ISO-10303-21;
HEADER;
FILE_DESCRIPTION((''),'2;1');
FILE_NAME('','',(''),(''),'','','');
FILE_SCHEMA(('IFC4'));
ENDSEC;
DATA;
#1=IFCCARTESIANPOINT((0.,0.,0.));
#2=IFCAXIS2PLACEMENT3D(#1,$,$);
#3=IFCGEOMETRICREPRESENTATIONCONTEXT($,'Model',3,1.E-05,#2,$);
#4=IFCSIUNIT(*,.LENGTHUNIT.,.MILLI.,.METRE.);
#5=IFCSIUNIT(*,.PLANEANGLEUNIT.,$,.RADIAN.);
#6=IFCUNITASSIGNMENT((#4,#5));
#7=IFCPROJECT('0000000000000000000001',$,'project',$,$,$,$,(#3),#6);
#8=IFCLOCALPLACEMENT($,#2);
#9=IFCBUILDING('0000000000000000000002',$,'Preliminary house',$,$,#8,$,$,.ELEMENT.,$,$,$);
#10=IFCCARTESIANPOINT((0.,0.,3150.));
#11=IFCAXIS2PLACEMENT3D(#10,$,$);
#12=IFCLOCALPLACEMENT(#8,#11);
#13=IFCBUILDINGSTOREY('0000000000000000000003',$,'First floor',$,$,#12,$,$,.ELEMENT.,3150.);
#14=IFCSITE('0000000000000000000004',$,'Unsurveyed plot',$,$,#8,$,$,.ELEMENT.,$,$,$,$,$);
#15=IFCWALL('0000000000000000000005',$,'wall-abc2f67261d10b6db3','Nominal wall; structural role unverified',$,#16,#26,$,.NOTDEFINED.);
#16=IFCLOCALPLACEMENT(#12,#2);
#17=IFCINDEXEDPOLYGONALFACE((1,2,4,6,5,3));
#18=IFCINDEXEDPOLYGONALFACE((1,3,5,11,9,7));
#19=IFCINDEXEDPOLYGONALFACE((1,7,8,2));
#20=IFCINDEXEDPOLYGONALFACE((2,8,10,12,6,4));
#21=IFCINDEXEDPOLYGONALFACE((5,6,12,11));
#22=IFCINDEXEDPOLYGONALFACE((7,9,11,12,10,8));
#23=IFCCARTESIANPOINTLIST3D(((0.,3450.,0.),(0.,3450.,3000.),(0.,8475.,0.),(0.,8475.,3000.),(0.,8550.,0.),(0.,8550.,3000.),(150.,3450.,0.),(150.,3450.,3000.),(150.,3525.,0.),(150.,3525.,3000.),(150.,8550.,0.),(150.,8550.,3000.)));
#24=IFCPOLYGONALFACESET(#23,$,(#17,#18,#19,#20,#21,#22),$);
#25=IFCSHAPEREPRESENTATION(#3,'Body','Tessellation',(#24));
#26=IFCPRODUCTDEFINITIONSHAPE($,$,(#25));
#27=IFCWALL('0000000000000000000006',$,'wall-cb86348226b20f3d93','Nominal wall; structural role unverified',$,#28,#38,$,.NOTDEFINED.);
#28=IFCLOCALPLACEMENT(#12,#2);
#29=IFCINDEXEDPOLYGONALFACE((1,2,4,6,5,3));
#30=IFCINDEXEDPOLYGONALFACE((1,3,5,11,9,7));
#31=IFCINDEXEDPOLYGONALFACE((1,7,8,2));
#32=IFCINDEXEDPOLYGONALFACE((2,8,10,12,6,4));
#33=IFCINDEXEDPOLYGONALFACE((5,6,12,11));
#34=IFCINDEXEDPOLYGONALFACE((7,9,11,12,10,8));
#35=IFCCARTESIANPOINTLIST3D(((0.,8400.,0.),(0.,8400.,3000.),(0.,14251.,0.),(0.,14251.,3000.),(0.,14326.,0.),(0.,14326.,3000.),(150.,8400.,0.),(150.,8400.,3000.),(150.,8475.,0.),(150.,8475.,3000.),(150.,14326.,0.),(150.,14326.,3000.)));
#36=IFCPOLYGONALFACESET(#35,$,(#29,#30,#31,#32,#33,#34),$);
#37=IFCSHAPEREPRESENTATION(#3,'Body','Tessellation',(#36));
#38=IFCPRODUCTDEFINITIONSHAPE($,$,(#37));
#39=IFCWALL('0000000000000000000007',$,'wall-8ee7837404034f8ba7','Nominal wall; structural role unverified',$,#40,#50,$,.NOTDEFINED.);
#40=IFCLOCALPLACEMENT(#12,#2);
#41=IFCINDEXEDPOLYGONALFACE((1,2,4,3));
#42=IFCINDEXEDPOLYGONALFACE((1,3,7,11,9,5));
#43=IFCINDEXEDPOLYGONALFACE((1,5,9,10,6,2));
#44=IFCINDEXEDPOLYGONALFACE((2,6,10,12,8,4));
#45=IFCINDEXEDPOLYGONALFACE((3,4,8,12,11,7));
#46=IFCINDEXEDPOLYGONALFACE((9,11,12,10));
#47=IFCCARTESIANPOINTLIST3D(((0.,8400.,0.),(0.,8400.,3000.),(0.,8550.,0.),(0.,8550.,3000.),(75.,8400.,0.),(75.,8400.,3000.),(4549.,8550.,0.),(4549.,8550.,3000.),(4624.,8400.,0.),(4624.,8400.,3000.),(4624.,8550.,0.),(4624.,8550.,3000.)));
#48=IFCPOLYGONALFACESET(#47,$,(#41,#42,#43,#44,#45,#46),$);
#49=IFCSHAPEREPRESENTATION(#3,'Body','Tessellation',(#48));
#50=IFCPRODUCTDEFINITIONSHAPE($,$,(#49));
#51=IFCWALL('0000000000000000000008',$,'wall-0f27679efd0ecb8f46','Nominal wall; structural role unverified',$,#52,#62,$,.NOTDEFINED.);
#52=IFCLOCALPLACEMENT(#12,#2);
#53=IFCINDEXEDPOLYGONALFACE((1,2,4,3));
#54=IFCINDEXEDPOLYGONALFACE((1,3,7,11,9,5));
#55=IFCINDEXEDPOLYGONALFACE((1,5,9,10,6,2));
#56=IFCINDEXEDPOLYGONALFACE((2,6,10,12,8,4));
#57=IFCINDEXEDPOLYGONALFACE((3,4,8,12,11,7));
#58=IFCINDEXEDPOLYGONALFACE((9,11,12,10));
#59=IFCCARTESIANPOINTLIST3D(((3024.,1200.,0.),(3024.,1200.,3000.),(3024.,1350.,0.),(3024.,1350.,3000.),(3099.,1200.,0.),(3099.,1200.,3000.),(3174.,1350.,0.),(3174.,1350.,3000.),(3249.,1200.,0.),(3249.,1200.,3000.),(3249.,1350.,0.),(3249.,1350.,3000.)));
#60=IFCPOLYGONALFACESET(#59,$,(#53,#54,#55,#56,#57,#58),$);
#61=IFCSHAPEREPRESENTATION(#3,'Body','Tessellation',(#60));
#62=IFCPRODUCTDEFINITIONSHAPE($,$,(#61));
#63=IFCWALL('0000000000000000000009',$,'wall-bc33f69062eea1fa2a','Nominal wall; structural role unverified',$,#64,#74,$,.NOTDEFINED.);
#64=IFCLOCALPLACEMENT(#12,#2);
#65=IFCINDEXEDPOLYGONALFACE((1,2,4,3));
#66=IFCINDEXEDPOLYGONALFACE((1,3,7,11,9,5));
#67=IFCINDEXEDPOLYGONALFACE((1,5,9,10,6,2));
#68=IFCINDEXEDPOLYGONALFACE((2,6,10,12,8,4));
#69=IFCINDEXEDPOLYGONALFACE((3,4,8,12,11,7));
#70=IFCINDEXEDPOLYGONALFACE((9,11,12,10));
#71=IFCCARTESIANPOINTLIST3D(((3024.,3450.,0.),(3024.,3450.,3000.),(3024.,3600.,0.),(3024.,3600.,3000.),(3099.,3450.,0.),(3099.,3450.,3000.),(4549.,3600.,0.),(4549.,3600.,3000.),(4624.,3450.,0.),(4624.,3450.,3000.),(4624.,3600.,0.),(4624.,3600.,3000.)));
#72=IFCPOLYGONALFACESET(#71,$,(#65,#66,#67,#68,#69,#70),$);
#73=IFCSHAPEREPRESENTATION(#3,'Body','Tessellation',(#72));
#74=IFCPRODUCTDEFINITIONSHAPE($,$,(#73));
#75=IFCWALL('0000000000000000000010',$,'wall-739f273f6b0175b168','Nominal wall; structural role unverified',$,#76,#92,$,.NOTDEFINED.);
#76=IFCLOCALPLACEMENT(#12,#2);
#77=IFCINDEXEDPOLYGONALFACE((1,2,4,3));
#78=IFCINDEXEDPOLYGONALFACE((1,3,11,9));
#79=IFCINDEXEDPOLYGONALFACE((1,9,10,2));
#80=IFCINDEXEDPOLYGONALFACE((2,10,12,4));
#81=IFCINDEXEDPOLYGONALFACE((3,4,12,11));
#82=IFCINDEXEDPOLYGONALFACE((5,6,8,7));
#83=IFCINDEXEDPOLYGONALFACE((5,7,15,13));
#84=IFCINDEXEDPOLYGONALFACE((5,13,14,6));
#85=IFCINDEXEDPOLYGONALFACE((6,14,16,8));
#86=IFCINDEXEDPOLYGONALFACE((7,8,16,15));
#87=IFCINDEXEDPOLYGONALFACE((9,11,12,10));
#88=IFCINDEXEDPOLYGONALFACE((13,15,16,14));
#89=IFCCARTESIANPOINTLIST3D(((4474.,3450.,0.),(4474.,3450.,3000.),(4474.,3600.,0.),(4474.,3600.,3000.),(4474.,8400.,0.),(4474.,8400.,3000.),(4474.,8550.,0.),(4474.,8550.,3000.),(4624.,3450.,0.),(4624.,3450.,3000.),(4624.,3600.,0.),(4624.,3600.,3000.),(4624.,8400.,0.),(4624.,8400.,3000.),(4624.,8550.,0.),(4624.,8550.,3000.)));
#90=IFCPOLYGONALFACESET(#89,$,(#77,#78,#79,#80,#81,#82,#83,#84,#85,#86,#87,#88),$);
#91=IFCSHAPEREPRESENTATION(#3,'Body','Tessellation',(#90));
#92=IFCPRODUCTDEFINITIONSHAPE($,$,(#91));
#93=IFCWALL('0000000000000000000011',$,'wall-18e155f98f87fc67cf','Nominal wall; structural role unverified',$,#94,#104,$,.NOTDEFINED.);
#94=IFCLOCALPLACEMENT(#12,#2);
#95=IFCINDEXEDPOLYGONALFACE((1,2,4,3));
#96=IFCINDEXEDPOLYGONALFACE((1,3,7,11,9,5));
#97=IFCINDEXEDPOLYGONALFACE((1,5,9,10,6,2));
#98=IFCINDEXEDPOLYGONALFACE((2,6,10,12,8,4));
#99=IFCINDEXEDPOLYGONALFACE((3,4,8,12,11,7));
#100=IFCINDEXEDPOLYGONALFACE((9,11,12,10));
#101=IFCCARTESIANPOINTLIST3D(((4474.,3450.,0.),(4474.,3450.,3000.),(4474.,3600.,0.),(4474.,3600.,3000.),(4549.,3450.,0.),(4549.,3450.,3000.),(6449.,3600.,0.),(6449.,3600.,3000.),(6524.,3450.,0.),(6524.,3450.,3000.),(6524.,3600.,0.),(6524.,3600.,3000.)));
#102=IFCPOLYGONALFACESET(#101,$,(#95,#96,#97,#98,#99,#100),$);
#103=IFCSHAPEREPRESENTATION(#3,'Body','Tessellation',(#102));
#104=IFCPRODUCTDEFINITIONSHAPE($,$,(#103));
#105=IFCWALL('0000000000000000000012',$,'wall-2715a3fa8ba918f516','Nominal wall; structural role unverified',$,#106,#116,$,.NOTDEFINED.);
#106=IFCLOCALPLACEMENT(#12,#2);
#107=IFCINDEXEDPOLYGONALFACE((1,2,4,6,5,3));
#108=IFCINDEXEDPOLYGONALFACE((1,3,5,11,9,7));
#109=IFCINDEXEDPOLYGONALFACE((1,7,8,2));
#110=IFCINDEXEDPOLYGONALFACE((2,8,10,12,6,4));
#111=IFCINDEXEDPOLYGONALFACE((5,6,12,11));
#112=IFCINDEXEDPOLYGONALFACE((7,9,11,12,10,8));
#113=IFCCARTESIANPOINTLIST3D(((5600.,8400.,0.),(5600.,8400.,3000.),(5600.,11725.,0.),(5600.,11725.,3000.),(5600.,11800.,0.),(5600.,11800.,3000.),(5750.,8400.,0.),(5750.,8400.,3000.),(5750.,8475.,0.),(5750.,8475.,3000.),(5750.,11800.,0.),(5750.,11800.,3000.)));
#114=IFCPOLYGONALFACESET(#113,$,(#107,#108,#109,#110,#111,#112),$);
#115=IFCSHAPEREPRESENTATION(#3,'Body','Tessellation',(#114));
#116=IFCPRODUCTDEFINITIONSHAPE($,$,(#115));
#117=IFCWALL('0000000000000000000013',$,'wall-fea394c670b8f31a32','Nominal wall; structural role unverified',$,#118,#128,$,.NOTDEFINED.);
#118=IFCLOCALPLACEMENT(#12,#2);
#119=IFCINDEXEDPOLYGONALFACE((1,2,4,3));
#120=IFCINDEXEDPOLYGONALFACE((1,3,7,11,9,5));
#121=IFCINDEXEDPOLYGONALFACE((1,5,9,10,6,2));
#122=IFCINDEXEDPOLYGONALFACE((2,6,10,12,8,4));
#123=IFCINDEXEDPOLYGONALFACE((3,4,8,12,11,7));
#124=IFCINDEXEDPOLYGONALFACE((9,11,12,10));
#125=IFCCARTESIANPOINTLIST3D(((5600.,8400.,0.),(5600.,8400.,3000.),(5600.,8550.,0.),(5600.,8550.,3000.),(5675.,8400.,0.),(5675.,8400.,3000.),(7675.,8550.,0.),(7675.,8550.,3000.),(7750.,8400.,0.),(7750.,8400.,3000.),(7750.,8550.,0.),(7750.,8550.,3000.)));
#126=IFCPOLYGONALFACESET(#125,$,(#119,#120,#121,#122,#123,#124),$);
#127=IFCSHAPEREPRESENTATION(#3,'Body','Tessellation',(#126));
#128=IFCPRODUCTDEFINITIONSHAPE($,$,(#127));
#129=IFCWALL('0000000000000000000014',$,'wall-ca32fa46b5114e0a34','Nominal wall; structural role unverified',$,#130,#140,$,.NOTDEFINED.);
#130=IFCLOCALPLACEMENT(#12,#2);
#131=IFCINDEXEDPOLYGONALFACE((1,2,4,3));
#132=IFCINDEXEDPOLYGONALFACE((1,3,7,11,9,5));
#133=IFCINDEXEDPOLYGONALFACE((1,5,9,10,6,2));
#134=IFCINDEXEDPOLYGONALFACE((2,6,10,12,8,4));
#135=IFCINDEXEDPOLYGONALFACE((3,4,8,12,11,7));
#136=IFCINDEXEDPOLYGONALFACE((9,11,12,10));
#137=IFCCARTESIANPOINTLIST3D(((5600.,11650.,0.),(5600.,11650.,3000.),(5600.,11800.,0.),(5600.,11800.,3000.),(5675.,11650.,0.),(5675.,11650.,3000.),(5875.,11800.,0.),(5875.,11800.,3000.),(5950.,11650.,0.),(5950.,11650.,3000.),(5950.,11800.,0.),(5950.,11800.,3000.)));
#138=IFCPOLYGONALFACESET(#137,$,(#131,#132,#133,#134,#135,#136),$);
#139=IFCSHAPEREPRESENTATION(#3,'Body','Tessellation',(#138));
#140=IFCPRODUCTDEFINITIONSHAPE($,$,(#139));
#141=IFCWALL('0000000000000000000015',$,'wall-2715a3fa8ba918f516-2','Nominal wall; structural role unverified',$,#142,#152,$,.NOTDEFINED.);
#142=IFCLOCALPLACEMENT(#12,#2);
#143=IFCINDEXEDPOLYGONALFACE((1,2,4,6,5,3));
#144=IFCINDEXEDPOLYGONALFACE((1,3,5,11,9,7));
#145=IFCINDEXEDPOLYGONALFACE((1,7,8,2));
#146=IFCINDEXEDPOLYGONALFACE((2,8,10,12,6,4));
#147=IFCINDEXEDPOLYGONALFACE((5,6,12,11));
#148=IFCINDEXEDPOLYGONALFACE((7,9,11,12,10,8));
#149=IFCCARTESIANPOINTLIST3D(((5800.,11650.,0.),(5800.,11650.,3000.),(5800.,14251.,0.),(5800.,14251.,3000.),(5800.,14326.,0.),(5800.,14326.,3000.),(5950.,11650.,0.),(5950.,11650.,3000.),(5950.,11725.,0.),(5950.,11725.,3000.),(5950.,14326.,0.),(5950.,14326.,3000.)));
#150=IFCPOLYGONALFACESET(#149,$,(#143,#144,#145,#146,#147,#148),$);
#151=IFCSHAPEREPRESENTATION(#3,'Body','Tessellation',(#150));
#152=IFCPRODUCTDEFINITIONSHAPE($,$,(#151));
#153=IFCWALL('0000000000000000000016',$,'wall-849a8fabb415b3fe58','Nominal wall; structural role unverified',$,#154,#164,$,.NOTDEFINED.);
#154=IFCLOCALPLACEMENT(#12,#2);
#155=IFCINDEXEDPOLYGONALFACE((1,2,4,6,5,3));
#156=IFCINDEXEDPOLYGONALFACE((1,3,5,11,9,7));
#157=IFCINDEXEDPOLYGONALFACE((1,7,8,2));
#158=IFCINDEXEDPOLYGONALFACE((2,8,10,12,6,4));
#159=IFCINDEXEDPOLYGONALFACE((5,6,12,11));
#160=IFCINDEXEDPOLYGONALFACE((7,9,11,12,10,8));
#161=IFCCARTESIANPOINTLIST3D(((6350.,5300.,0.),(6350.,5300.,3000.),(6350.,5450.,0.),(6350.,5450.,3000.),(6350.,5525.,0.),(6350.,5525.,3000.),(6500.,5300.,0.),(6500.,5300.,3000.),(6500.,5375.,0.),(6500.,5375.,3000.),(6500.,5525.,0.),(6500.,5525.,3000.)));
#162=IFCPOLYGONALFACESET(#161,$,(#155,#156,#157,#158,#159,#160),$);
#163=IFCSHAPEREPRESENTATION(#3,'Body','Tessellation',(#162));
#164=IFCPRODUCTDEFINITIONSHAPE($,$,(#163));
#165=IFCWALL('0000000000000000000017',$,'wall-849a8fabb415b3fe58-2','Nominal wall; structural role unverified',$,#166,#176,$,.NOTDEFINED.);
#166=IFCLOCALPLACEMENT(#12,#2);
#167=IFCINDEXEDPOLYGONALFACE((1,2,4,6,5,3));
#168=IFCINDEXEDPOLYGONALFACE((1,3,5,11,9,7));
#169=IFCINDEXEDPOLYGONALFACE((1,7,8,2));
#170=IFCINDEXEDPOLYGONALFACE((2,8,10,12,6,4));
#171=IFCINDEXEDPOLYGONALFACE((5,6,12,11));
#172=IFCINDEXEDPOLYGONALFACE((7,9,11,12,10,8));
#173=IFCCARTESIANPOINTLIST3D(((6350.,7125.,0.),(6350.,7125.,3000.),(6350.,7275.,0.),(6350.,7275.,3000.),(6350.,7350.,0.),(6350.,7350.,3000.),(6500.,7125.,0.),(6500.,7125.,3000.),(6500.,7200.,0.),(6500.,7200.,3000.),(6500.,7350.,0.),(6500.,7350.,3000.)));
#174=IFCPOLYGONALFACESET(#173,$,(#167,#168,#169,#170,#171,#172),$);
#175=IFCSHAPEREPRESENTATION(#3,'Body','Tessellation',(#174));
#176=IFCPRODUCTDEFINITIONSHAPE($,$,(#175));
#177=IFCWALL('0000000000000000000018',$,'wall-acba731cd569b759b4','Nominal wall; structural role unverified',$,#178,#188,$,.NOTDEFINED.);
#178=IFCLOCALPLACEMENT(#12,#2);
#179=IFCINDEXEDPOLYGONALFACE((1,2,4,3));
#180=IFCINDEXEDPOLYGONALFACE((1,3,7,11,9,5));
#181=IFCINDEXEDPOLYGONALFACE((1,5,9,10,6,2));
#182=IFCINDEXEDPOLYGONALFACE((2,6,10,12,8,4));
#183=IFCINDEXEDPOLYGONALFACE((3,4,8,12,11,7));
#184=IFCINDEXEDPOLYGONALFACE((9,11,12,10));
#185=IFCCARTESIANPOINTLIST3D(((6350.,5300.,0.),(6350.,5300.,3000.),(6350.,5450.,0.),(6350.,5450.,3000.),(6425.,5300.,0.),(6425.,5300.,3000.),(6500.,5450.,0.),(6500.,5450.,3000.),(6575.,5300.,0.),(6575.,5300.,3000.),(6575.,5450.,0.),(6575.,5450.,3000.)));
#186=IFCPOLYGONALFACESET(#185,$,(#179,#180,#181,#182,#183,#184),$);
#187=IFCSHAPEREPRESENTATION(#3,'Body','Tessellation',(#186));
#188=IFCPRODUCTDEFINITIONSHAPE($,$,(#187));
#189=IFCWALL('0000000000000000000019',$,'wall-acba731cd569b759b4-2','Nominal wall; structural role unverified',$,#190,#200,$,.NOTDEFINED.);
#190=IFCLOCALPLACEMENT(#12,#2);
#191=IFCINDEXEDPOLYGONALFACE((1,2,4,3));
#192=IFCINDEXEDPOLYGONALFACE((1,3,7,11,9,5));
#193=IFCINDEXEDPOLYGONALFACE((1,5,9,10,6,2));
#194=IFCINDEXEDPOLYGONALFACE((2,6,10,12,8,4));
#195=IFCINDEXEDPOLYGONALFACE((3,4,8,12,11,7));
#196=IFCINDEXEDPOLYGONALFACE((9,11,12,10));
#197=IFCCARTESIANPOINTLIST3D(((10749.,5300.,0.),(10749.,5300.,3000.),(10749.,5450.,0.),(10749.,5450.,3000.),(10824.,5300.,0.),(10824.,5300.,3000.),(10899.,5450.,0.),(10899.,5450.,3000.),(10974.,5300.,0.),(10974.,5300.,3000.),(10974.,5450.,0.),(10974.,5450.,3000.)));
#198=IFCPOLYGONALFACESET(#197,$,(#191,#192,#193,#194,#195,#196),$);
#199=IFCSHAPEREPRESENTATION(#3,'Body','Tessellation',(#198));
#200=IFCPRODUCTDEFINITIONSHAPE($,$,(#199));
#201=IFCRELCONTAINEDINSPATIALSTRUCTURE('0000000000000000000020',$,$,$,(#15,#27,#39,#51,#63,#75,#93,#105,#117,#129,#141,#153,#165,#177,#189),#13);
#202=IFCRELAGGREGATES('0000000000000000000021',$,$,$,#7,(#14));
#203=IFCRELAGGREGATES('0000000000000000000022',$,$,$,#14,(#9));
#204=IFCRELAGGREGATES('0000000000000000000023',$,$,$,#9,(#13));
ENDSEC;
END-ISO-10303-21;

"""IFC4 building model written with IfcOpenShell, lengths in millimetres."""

from ifc_helpers import new_model, si_unit, frame, origin, place, context, project, spatial, polyline, outline, extrude, element, save


model = new_model("IFC4")

# Units and contexts
model_context = context("Model", 3, precision=1e-05, world=origin())
ifc_project = project(units=[si_unit("LENGTHUNIT", "METRE", prefix="MILLI"), si_unit("PLANEANGLEUNIT", "RADIAN")], contexts=[model_context])

# Site, building, storey
placement_1 = place(None, origin())
site = spatial("IfcSite", under=ifc_project, at=placement_1, Name="Unsurveyed plot", CompositionType="ELEMENT")
building = spatial("IfcBuilding", under=site, at=placement_1, Name="Preliminary house", CompositionType="ELEMENT")
placement_2 = place(placement_1, frame((0.0, 0.0, 3150.0)))
storey = spatial("IfcBuildingStorey", under=building, at=placement_2, Name="First floor", CompositionType="ELEMENT", Elevation=3150.0)

# Wall
element("IfcWall", 1, at=placement_2, inside=storey, Name="wall-abc2f67261d10b6db3", Description="Nominal wall; structural role unverified", PredefinedType="NOTDEFINED", context=model_context, shape_type="SweptSolid", body=[
    extrude(outline(polyline([(0.0, 8475.0), (0.0, 8550.0), (150.0, 8550.0), (150.0, 3525.0), (150.0, 3450.0), (0.0, 3450.0), (0.0, 8475.0)])), origin(), (0.0, 0.0, 1.0), 3000.0),
])

# Walls
element("IfcWall", 2, at=placement_2, inside=storey, Name="wall-cb86348226b20f3d93", Description="Nominal wall; structural role unverified", PredefinedType="NOTDEFINED", context=model_context, shape_type="SweptSolid", body=[
    extrude(outline(polyline([(0.0, 14251.0), (0.0, 14326.0), (150.0, 14326.0), (150.0, 8475.0), (150.0, 8400.0), (0.0, 8400.0), (0.0, 14251.0)])), origin(), (0.0, 0.0, 1.0), 3000.0),
])
element("IfcWall", 3, at=placement_2, inside=storey, Name="wall-8ee7837404034f8ba7", Description="Nominal wall; structural role unverified", PredefinedType="NOTDEFINED", context=model_context, shape_type="SweptSolid", body=[
    extrude(outline(polyline([(4549.0, 8550.0), (4624.0, 8550.0), (4624.0, 8400.0), (75.0, 8400.0), (0.0, 8400.0), (0.0, 8550.0), (4549.0, 8550.0)])), origin(), (0.0, 0.0, 1.0), 3000.0),
])

# Wall
element("IfcWall", 4, at=placement_2, inside=storey, Name="wall-0f27679efd0ecb8f46", Description="Nominal wall; structural role unverified", PredefinedType="NOTDEFINED", context=model_context, shape_type="SweptSolid", body=[
    extrude(outline(polyline([(3174.0, 1350.0), (3249.0, 1350.0), (3249.0, 1200.0), (3099.0, 1200.0), (3024.0, 1200.0), (3024.0, 1350.0), (3174.0, 1350.0)])), origin(), (0.0, 0.0, 1.0), 3000.0),
])

# Wall
element("IfcWall", 5, at=placement_2, inside=storey, Name="wall-bc33f69062eea1fa2a", Description="Nominal wall; structural role unverified", PredefinedType="NOTDEFINED", context=model_context, shape_type="SweptSolid", body=[
    extrude(outline(polyline([(4549.0, 3600.0), (4624.0, 3600.0), (4624.0, 3450.0), (3099.0, 3450.0), (3024.0, 3450.0), (3024.0, 3600.0), (4549.0, 3600.0)])), origin(), (0.0, 0.0, 1.0), 3000.0),
])

# Wall, opening
wall_1 = element("IfcWall", 6, at=placement_2, inside=storey, Name="wall-739f273f6b0175b168", Description="Nominal wall; structural role unverified", PredefinedType="NOTDEFINED", context=model_context, shape_type="SweptSolid", body=[
    extrude(outline(polyline([(4474.0, 8475.0), (4474.0, 8550.0), (4624.0, 8550.0), (4624.0, 3525.0), (4624.0, 3450.0), (4474.0, 3450.0), (4474.0, 8475.0)])), origin(), (0.0, 0.0, 1.0), 3000.0),
])
element("IfcOpeningElement", 7, at=placement_2, cuts=wall_1, PredefinedType="OPENING", context=model_context, shape_type="SweptSolid", body=[
    extrude(outline(polyline([(4999.0, 3600.0), (4999.0, 8400.0), (4099.0, 8400.0), (4099.0, 3600.0), (4999.0, 3600.0)])), origin(), (0.0, 0.0, 1.0), 3000.0),
])

# Wall
element("IfcWall", 8, at=placement_2, inside=storey, Name="wall-18e155f98f87fc67cf", Description="Nominal wall; structural role unverified", PredefinedType="NOTDEFINED", context=model_context, shape_type="SweptSolid", body=[
    extrude(outline(polyline([(6449.0, 3600.0), (6524.0, 3600.0), (6524.0, 3450.0), (4549.0, 3450.0), (4474.0, 3450.0), (4474.0, 3600.0), (6449.0, 3600.0)])), origin(), (0.0, 0.0, 1.0), 3000.0),
])

# Walls
element("IfcWall", 9, at=placement_2, inside=storey, Name="wall-2715a3fa8ba918f516", Description="Nominal wall; structural role unverified", PredefinedType="NOTDEFINED", context=model_context, shape_type="SweptSolid", body=[
    extrude(outline(polyline([(5600.0, 11725.0), (5600.0, 11800.0), (5750.0, 11800.0), (5750.0, 8475.0), (5750.0, 8400.0), (5600.0, 8400.0), (5600.0, 11725.0)])), origin(), (0.0, 0.0, 1.0), 3000.0),
])
element("IfcWall", 10, at=placement_2, inside=storey, Name="wall-fea394c670b8f31a32", Description="Nominal wall; structural role unverified", PredefinedType="NOTDEFINED", context=model_context, shape_type="SweptSolid", body=[
    extrude(outline(polyline([(7675.0, 8550.0), (7750.0, 8550.0), (7750.0, 8400.0), (5675.0, 8400.0), (5600.0, 8400.0), (5600.0, 8550.0), (7675.0, 8550.0)])), origin(), (0.0, 0.0, 1.0), 3000.0),
])
element("IfcWall", 11, at=placement_2, inside=storey, Name="wall-ca32fa46b5114e0a34", Description="Nominal wall; structural role unverified", PredefinedType="NOTDEFINED", context=model_context, shape_type="SweptSolid", body=[
    extrude(outline(polyline([(5875.0, 11800.0), (5950.0, 11800.0), (5950.0, 11650.0), (5675.0, 11650.0), (5600.0, 11650.0), (5600.0, 11800.0), (5875.0, 11800.0)])), origin(), (0.0, 0.0, 1.0), 3000.0),
])
element("IfcWall", 12, at=placement_2, inside=storey, Name="wall-2715a3fa8ba918f516-2", Description="Nominal wall; structural role unverified", PredefinedType="NOTDEFINED", context=model_context, shape_type="SweptSolid", body=[
    extrude(outline(polyline([(5800.0, 14251.0), (5800.0, 14326.0), (5950.0, 14326.0), (5950.0, 11725.0), (5950.0, 11650.0), (5800.0, 11650.0), (5800.0, 14251.0)])), origin(), (0.0, 0.0, 1.0), 3000.0),
])
element("IfcWall", 13, at=placement_2, inside=storey, Name="wall-849a8fabb415b3fe58", Description="Nominal wall; structural role unverified", PredefinedType="NOTDEFINED", context=model_context, shape_type="SweptSolid", body=[
    extrude(outline(polyline([(6350.0, 5450.0), (6350.0, 5525.0), (6500.0, 5525.0), (6500.0, 5375.0), (6500.0, 5300.0), (6350.0, 5300.0), (6350.0, 5450.0)])), origin(), (0.0, 0.0, 1.0), 3000.0),
])
element("IfcWall", 14, at=placement_2, inside=storey, Name="wall-849a8fabb415b3fe58-2", Description="Nominal wall; structural role unverified", PredefinedType="NOTDEFINED", context=model_context, shape_type="SweptSolid", body=[
    extrude(outline(polyline([(6350.0, 7275.0), (6350.0, 7350.0), (6500.0, 7350.0), (6500.0, 7200.0), (6500.0, 7125.0), (6350.0, 7125.0), (6350.0, 7275.0)])), origin(), (0.0, 0.0, 1.0), 3000.0),
])
element("IfcWall", 15, at=placement_2, inside=storey, Name="wall-acba731cd569b759b4", Description="Nominal wall; structural role unverified", PredefinedType="NOTDEFINED", context=model_context, shape_type="SweptSolid", body=[
    extrude(outline(polyline([(6500.0, 5450.0), (6575.0, 5450.0), (6575.0, 5300.0), (6425.0, 5300.0), (6350.0, 5300.0), (6350.0, 5450.0), (6500.0, 5450.0)])), origin(), (0.0, 0.0, 1.0), 3000.0),
])
element("IfcWall", 16, at=placement_2, inside=storey, Name="wall-acba731cd569b759b4-2", Description="Nominal wall; structural role unverified", PredefinedType="NOTDEFINED", context=model_context, shape_type="SweptSolid", body=[
    extrude(outline(polyline([(10899.0, 5450.0), (10974.0, 5450.0), (10974.0, 5300.0), (10824.0, 5300.0), (10749.0, 5300.0), (10749.0, 5450.0), (10899.0, 5450.0)])), origin(), (0.0, 0.0, 1.0), 3000.0),
])

save(model, "model.ifc")
